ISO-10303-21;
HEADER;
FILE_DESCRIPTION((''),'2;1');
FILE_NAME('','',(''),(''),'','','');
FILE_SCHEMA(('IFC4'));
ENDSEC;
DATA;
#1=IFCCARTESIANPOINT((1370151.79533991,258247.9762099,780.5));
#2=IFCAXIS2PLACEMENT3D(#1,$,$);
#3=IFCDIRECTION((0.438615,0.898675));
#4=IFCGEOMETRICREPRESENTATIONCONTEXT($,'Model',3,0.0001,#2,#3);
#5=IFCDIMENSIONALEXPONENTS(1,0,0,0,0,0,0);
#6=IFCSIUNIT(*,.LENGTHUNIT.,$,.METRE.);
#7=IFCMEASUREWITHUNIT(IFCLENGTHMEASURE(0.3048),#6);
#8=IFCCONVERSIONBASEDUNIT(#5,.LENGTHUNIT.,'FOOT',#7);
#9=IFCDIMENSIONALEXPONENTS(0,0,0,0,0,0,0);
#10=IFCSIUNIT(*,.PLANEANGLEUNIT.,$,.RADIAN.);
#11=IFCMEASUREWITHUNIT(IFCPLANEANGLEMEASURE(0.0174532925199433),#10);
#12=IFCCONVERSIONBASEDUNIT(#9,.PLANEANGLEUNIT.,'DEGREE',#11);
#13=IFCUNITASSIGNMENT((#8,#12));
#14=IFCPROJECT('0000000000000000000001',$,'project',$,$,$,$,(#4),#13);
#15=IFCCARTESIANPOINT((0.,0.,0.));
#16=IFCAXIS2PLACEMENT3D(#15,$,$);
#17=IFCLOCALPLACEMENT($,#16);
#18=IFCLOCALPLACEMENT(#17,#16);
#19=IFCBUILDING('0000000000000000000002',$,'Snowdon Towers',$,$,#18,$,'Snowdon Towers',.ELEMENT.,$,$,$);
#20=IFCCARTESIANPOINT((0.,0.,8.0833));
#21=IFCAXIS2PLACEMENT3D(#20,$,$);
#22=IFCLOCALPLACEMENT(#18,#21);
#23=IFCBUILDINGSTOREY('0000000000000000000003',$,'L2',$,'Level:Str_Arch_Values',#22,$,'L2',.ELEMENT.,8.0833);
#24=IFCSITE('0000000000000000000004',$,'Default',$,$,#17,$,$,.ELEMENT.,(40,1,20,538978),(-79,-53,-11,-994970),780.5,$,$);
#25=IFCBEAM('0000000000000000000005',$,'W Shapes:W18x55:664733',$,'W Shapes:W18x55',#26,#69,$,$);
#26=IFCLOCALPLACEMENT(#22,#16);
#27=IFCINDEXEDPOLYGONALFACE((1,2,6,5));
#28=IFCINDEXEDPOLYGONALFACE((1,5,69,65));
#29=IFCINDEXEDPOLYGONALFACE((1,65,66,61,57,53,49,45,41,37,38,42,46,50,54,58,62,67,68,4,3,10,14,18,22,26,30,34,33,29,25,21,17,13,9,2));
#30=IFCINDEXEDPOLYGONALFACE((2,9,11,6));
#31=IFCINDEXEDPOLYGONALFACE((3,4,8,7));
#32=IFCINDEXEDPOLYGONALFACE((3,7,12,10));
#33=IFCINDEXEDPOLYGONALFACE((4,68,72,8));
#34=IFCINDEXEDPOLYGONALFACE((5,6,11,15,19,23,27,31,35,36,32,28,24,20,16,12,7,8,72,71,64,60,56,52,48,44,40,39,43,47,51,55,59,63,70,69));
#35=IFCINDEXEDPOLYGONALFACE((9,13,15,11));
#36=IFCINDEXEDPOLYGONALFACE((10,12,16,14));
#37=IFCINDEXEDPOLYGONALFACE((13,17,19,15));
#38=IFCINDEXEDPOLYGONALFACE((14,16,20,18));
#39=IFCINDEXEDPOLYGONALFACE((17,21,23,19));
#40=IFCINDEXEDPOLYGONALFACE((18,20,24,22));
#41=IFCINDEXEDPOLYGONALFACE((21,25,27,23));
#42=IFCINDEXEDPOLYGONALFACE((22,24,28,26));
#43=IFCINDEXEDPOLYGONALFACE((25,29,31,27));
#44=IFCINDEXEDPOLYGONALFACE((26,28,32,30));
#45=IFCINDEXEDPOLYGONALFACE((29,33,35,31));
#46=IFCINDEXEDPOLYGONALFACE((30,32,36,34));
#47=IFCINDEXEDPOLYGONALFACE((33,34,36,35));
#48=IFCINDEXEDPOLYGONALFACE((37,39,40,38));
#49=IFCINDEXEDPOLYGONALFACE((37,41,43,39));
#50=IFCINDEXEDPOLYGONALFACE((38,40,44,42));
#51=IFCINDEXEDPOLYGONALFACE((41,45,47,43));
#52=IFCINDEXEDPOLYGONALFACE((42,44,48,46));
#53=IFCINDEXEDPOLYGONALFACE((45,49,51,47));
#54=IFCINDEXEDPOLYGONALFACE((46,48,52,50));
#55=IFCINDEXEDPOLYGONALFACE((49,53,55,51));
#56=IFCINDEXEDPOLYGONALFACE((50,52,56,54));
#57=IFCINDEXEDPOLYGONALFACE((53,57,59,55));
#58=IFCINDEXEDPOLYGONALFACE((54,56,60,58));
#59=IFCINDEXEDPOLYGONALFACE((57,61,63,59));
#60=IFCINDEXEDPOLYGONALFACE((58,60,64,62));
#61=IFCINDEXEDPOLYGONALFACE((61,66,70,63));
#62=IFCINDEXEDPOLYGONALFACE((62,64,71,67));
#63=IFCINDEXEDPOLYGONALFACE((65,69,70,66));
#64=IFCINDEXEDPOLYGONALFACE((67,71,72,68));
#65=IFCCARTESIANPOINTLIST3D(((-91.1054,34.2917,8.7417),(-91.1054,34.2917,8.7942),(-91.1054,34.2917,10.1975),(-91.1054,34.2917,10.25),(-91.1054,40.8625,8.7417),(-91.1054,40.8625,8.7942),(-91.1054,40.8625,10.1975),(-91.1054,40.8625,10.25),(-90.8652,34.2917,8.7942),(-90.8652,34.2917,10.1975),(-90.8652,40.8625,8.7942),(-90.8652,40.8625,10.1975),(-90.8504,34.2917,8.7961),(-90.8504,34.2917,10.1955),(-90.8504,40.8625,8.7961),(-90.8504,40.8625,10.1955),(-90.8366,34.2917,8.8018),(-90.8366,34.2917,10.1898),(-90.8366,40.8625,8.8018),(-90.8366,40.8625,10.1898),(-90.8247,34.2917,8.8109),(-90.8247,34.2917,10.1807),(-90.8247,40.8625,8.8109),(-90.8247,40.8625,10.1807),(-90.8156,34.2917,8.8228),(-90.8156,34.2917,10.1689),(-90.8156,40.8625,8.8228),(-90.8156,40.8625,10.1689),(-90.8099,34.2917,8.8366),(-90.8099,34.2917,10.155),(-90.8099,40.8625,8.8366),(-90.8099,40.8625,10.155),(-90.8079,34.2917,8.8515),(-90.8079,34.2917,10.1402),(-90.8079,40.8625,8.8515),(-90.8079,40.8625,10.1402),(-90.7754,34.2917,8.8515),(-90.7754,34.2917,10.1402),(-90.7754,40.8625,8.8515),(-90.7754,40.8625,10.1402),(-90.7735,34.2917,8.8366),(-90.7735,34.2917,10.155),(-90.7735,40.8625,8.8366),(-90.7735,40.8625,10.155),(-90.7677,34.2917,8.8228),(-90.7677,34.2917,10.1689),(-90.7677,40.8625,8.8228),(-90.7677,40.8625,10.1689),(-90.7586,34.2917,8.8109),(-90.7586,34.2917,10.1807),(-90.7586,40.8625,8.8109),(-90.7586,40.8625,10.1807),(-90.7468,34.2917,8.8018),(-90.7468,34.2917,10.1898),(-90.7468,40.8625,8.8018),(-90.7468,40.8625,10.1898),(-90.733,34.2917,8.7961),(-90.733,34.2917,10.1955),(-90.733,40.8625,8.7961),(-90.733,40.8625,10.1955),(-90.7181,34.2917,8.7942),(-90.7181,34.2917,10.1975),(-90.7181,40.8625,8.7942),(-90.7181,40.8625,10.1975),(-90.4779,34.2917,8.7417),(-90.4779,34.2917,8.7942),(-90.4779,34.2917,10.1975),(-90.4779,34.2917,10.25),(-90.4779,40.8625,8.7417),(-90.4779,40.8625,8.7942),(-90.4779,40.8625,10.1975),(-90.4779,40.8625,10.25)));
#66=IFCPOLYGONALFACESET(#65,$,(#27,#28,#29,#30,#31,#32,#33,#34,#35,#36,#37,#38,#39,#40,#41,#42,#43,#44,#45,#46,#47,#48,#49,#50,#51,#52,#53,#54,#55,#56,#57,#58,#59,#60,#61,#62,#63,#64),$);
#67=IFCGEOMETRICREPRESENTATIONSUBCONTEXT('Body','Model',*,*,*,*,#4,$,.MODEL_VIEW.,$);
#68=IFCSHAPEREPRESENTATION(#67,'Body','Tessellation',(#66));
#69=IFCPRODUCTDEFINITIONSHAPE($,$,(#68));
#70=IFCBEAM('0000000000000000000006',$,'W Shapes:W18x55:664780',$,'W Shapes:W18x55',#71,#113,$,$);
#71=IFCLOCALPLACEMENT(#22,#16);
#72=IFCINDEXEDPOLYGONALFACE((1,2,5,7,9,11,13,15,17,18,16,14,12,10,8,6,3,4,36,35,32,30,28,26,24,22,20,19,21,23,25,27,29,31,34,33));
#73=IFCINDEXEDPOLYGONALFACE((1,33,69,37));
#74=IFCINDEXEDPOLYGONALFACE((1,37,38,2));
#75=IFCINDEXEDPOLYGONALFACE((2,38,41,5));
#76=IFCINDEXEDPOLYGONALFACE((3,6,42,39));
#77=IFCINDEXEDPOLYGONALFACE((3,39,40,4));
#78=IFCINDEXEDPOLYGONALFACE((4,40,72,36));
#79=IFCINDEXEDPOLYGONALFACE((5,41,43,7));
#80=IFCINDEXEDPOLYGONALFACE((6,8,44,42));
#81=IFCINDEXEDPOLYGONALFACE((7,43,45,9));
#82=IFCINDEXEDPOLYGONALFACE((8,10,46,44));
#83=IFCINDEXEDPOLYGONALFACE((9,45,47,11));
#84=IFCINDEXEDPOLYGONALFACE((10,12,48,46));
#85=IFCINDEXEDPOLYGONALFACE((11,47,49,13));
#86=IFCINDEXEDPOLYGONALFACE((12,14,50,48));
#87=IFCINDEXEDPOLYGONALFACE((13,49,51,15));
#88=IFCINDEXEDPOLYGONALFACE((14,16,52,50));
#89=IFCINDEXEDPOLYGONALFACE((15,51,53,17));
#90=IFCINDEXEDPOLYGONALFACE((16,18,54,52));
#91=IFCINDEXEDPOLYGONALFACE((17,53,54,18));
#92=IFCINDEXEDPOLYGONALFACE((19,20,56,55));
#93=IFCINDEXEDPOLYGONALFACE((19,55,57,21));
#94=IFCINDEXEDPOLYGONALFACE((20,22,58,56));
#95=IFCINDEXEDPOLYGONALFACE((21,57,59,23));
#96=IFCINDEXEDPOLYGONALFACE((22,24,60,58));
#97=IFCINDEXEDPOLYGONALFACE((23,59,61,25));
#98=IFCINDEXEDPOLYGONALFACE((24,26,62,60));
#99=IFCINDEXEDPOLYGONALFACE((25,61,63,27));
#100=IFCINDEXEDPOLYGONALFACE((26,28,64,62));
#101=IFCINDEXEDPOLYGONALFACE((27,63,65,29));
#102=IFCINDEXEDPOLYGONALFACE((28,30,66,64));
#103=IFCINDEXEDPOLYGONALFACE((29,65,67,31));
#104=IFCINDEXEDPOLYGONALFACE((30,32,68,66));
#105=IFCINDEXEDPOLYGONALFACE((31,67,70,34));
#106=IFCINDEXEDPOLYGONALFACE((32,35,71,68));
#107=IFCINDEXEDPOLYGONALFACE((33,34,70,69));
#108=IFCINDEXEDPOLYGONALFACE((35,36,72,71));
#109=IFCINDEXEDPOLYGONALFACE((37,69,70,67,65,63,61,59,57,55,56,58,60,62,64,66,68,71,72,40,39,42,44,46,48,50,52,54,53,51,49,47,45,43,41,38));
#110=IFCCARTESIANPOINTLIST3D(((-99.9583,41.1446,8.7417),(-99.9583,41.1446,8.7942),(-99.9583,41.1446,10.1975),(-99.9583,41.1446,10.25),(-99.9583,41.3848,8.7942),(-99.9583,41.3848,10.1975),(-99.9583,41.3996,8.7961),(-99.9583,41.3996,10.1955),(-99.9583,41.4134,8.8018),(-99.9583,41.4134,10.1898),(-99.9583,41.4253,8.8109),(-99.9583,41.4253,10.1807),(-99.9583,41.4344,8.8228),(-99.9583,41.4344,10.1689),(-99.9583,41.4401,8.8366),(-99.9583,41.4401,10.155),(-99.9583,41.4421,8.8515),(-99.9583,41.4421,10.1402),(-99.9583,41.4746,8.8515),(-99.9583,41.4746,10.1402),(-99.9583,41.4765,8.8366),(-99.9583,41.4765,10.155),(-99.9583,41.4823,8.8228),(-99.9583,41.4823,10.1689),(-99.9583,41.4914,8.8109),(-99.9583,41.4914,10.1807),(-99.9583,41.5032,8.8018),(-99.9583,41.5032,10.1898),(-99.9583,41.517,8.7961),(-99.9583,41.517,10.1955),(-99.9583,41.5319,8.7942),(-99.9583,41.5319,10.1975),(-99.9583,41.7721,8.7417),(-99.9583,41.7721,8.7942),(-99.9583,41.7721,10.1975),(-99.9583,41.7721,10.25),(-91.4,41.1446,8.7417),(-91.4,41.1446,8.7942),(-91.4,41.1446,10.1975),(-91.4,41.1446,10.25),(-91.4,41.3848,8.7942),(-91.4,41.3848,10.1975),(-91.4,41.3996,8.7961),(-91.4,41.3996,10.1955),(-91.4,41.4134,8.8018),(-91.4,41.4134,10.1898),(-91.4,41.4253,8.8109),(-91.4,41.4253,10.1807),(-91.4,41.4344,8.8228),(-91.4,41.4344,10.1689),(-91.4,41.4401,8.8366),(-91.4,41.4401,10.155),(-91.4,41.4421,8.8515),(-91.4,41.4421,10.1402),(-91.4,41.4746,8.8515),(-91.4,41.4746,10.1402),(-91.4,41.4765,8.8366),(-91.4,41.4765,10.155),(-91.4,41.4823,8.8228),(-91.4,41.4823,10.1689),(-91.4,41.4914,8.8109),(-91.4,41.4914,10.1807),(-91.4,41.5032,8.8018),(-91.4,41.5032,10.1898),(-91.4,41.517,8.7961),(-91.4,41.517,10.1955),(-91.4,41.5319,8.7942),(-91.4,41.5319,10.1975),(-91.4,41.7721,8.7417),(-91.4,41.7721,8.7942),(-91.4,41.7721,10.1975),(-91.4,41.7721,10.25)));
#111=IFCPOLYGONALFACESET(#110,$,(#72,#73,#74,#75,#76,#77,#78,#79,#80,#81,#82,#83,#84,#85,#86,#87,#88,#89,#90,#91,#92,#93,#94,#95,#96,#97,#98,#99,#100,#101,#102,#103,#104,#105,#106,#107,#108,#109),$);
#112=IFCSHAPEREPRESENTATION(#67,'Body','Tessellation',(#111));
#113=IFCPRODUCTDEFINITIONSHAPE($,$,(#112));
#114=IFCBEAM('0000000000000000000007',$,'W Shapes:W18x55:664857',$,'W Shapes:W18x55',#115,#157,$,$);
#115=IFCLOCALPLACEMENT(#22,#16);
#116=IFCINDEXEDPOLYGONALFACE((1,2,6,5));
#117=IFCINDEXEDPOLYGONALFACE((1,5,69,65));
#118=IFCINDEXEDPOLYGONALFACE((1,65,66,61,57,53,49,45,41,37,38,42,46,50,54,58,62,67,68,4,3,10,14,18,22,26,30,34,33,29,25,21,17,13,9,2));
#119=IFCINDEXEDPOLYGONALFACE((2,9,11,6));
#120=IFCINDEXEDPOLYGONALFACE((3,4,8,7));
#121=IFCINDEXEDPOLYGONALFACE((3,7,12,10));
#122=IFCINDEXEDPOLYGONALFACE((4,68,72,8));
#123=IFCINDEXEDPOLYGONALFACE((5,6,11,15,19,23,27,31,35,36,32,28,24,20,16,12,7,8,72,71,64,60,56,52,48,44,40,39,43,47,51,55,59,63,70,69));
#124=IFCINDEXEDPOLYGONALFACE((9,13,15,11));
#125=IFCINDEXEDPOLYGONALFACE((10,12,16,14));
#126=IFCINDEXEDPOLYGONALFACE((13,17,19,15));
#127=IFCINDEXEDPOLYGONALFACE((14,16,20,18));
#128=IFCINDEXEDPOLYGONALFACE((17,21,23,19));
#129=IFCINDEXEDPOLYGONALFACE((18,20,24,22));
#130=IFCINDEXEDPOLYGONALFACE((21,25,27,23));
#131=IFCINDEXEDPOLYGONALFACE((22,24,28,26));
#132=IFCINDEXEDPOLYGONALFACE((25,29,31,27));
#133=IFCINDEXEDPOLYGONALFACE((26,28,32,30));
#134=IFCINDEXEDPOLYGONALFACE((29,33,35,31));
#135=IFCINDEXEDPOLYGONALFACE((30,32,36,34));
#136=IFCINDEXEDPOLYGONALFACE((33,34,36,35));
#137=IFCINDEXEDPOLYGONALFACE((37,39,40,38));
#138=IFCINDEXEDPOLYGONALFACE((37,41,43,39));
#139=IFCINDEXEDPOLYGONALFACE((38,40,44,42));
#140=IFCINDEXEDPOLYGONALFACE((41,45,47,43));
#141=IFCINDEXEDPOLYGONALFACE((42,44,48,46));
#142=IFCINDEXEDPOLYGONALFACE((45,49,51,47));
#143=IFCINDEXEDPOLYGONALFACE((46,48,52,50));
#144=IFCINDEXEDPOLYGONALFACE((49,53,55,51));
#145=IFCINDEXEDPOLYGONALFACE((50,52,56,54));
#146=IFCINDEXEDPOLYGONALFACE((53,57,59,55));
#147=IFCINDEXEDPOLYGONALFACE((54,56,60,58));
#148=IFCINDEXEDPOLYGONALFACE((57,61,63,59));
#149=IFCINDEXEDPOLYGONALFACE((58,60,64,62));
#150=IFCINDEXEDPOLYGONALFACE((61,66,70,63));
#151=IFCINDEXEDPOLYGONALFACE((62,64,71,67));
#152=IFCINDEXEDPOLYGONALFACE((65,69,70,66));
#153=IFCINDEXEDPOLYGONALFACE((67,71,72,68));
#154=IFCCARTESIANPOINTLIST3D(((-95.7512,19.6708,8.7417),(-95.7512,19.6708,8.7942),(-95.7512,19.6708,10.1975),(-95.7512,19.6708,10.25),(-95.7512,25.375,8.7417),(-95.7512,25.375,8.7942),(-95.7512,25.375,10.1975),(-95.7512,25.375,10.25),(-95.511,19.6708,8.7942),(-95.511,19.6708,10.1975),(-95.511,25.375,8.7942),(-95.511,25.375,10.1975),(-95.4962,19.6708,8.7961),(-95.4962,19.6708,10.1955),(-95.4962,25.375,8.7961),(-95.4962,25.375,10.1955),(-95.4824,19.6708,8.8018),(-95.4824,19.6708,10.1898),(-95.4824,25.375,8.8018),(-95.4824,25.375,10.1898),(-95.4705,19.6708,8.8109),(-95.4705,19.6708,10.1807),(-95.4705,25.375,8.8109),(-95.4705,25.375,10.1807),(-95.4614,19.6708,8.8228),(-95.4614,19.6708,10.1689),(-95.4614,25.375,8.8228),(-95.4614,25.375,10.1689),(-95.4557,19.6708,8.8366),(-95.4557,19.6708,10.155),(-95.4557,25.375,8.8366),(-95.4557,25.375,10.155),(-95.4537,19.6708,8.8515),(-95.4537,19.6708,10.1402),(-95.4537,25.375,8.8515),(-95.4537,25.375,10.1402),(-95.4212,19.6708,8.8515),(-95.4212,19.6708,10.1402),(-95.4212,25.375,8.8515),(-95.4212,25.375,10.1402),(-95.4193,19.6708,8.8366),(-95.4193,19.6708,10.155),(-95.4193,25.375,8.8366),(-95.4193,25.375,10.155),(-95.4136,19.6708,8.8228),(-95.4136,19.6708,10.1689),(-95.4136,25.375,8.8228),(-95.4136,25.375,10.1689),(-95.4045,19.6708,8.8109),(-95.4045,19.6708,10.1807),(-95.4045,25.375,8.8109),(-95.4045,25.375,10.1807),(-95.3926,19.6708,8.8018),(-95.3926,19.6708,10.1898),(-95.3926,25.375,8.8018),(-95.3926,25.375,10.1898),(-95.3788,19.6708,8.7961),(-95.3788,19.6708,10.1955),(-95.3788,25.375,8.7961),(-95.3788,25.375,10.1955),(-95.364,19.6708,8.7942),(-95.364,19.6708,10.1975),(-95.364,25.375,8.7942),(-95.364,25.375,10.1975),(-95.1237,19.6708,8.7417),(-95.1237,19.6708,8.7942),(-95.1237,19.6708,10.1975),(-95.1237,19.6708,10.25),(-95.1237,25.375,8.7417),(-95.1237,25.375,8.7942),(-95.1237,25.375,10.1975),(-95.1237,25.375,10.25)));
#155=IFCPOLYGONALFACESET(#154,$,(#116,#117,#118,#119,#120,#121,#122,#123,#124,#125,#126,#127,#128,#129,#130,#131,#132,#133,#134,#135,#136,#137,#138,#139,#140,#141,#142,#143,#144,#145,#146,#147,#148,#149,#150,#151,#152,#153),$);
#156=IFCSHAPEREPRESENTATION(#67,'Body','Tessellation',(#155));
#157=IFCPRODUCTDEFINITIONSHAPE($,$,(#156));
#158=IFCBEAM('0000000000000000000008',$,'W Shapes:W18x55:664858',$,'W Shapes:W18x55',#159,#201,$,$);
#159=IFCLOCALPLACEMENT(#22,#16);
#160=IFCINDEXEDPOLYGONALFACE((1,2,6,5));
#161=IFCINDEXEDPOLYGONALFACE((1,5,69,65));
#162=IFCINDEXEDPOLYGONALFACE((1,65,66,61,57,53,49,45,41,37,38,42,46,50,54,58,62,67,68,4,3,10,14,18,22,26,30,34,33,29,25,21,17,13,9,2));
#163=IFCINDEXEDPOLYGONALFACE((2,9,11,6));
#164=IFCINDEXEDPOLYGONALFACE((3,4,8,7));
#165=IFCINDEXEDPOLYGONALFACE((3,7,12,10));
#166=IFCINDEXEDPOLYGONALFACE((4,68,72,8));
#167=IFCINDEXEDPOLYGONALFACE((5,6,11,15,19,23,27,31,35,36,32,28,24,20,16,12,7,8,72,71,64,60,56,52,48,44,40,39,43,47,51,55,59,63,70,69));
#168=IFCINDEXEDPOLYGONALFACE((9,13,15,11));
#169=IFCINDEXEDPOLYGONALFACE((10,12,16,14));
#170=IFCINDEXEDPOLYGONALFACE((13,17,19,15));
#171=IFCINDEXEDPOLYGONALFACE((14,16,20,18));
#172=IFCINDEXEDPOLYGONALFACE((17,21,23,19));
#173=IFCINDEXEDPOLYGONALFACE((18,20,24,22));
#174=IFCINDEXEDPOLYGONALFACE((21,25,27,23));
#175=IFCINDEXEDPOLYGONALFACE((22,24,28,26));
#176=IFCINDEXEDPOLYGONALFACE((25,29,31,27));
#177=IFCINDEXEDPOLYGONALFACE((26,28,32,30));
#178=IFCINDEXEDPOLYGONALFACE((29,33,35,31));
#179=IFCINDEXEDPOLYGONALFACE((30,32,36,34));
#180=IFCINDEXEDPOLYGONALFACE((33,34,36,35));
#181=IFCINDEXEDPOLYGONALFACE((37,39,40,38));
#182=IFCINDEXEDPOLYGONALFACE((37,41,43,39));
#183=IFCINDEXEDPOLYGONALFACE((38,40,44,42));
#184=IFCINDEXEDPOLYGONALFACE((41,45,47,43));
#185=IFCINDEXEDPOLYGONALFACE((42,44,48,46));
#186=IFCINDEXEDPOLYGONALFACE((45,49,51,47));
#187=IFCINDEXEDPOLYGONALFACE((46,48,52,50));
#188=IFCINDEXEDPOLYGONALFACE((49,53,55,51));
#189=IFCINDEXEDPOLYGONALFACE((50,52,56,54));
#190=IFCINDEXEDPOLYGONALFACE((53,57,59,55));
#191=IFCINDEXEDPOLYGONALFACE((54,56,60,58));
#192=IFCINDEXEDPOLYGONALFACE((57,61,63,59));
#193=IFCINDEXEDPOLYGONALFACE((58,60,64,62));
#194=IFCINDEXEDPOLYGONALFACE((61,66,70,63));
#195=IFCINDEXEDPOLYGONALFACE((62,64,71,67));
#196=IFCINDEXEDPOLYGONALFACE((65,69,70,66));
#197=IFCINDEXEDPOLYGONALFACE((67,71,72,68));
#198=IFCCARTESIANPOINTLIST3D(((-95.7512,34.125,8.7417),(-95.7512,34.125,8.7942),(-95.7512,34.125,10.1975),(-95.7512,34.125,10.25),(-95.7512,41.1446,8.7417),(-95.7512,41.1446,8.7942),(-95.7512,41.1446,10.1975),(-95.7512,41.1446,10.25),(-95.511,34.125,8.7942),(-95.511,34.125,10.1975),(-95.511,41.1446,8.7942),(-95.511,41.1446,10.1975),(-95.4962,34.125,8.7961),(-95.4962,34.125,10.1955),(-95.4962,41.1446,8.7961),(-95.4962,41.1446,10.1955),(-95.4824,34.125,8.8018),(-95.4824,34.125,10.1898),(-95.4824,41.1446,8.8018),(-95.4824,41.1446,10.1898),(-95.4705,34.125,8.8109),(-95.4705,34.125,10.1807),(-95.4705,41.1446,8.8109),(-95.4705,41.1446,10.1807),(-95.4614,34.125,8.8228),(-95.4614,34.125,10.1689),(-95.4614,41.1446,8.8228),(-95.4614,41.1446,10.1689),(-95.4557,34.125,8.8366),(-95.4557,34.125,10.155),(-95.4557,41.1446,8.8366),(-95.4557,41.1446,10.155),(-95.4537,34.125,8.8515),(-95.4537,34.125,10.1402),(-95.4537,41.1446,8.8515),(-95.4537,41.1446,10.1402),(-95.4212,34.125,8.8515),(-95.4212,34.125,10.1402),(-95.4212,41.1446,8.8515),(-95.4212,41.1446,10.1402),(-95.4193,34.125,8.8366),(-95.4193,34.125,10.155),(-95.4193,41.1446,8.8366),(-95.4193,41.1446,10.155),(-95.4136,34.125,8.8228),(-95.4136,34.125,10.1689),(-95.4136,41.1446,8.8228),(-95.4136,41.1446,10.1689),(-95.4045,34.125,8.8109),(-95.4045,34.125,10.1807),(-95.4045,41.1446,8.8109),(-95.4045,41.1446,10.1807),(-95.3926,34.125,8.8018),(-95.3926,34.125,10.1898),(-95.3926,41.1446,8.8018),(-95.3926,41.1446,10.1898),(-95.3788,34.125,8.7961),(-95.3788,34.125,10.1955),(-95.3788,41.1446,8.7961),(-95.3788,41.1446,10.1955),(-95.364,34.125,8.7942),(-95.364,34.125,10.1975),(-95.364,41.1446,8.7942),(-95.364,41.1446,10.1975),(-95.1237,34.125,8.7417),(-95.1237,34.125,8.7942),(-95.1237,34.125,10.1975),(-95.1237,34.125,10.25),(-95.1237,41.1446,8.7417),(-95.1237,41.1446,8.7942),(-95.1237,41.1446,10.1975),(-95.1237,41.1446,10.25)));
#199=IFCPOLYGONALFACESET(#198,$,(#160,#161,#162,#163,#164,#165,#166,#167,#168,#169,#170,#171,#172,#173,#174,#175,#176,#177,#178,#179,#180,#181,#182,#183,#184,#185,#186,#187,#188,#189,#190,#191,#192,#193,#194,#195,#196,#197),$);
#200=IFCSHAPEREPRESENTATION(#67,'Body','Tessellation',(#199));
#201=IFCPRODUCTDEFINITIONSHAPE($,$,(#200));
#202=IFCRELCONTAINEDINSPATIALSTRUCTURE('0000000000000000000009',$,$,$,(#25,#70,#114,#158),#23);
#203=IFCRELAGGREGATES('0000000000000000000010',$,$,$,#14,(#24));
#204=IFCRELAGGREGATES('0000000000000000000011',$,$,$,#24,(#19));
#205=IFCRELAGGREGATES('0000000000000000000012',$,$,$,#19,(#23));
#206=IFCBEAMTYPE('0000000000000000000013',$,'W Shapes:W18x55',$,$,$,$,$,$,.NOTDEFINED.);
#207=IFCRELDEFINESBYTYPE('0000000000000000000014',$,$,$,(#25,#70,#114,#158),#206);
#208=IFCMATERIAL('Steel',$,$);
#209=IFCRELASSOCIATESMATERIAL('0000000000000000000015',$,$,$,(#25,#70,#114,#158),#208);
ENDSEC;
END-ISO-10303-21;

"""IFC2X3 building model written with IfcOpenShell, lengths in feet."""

from ifc_helpers import new_model, entity, si_unit, converted_unit, direction, frame, frame_2d, origin, place, context, subcontext, project, spatial, i_section, extrude, material, type_object, element, save


model = new_model("IFC2X3")

# Units and contexts
model_context = context("Model", 3, precision=0.0001, world=frame((1370151.79533991, 258247.9762099, 780.5)), true_north=direction((0.438615, 0.898675)))
body_context = subcontext(model_context, "Body", "Model", "MODEL_VIEW")
ifc_project = project(units=[converted_unit("LENGTHUNIT", "FOOT", entity("IfcLengthMeasure", 0.3048), si_unit("LENGTHUNIT", "METRE"), dimensions=[1, 0, 0, 0, 0, 0, 0]), converted_unit("PLANEANGLEUNIT", "DEGREE", entity("IfcPlaneAngleMeasure", 0.0174532925199433), si_unit("PLANEANGLEUNIT", "RADIAN"), dimensions=[0, 0, 0, 0, 0, 0, 0])], contexts=[model_context])

# Site, building, storey
site_placement = place(None, origin())
site = spatial("IfcSite", under=ifc_project, at=site_placement, Name="Default", CompositionType="ELEMENT", RefLatitude=(40, 1, 20, 538978), RefLongitude=(-79, -53, -11, -994970), RefElevation=780.5)
building_placement = place(site_placement, origin())
building = spatial("IfcBuilding", under=site, at=building_placement, Name="Snowdon Towers", LongName="Snowdon Towers", CompositionType="ELEMENT")
storey_placement = place(building_placement, frame((0.0, 0.0, 8.0833)))
storey = spatial("IfcBuildingStorey", under=building, at=storey_placement, Name="L2", ObjectType="Level:Str_Arch_Values", LongName="L2", CompositionType="ELEMENT", Elevation=8.0833)

# Beams
ifc_material = material(Name="Steel")
beam_type_1 = type_object("IfcBeamType", Name="W Shapes:W18x55", PredefinedType="NOTDEFINED")
beam_1_placement = place(storey_placement, frame((-90.7917, 41.4583, 10.25), z_axis=(0.0, 0.0, 1.0), x_axis=(0.0, -1.0, 0.0)))
element("IfcBeam", 1, at=beam_1_placement, inside=storey, type_object=beam_type_1, material=ifc_material, Name="W Shapes:W18x55:664733", ObjectType="W Shapes:W18x55", context=body_context, shape_type="SweptSolid", body=[
    extrude(i_section(OverallWidth=0.6275, OverallDepth=1.5083, WebThickness=0.0325, FlangeThickness=0.0525, FilletRadius=0.0573, at=frame_2d((0.0, 0.0), x_axis=(0.0, 1.0))), frame((0.5958, 0.0, -0.7542), z_axis=(1.0, 0.0, 0.0), x_axis=(0.0, 0.0, -1.0)), (0.0, 0.0, 1.0), 6.5708),
])
beam_2_placement = place(storey_placement, frame((-99.9583, 41.4583, 10.25)))
element("IfcBeam", 2, at=beam_2_placement, inside=storey, type_object=beam_type_1, material=ifc_material, Name="W Shapes:W18x55:664780", ObjectType="W Shapes:W18x55", context=body_context, shape_type="SweptSolid", body=[
    extrude(i_section(OverallWidth=0.6275, OverallDepth=1.5083, WebThickness=0.0325, FlangeThickness=0.0525, FilletRadius=0.0573, at=frame_2d((0.0, 0.0), x_axis=(0.0, 1.0))), frame((0.0, 0.0, -0.7542), z_axis=(1.0, 0.0, 0.0), x_axis=(0.0, 0.0, -1.0)), (0.0, 0.0, 1.0), 8.5583),
])
beam_3_placement = place(storey_placement, frame((-95.4375, 19.2083, 10.25), z_axis=(0.0, 0.0, 1.0), x_axis=(0.0, 1.0, 0.0)))
element("IfcBeam", 3, at=beam_3_placement, inside=storey, type_object=beam_type_1, material=ifc_material, Name="W Shapes:W18x55:664857", ObjectType="W Shapes:W18x55", context=body_context, shape_type="SweptSolid", body=[
    extrude(i_section(OverallWidth=0.6275, OverallDepth=1.5083, WebThickness=0.0325, FlangeThickness=0.0525, FilletRadius=0.0573, at=frame_2d((0.0, 0.0), x_axis=(0.0, 1.0))), frame((0.4625, 0.0, -0.7542), z_axis=(1.0, 0.0, 0.0), x_axis=(0.0, 0.0, -1.0)), (0.0, 0.0, 1.0), 5.7042),
])
beam_4_placement = place(storey_placement, frame((-95.4375, 41.4583, 10.25), z_axis=(0.0, 0.0, 1.0), x_axis=(0.0, -1.0, 0.0)))
element("IfcBeam", 4, at=beam_4_placement, inside=storey, type_object=beam_type_1, material=ifc_material, Name="W Shapes:W18x55:664858", ObjectType="W Shapes:W18x55", context=body_context, shape_type="SweptSolid", body=[
    extrude(i_section(OverallWidth=0.6275, OverallDepth=1.5083, WebThickness=0.0325, FlangeThickness=0.0525, FilletRadius=0.0573, at=frame_2d((0.0, 0.0), x_axis=(0.0, 1.0))), frame((0.3138, 0.0, -0.7542), z_axis=(1.0, 0.0, 0.0), x_axis=(0.0, 0.0, -1.0)), (0.0, 0.0, 1.0), 7.0196),
])

save(model, "model.ifc")
